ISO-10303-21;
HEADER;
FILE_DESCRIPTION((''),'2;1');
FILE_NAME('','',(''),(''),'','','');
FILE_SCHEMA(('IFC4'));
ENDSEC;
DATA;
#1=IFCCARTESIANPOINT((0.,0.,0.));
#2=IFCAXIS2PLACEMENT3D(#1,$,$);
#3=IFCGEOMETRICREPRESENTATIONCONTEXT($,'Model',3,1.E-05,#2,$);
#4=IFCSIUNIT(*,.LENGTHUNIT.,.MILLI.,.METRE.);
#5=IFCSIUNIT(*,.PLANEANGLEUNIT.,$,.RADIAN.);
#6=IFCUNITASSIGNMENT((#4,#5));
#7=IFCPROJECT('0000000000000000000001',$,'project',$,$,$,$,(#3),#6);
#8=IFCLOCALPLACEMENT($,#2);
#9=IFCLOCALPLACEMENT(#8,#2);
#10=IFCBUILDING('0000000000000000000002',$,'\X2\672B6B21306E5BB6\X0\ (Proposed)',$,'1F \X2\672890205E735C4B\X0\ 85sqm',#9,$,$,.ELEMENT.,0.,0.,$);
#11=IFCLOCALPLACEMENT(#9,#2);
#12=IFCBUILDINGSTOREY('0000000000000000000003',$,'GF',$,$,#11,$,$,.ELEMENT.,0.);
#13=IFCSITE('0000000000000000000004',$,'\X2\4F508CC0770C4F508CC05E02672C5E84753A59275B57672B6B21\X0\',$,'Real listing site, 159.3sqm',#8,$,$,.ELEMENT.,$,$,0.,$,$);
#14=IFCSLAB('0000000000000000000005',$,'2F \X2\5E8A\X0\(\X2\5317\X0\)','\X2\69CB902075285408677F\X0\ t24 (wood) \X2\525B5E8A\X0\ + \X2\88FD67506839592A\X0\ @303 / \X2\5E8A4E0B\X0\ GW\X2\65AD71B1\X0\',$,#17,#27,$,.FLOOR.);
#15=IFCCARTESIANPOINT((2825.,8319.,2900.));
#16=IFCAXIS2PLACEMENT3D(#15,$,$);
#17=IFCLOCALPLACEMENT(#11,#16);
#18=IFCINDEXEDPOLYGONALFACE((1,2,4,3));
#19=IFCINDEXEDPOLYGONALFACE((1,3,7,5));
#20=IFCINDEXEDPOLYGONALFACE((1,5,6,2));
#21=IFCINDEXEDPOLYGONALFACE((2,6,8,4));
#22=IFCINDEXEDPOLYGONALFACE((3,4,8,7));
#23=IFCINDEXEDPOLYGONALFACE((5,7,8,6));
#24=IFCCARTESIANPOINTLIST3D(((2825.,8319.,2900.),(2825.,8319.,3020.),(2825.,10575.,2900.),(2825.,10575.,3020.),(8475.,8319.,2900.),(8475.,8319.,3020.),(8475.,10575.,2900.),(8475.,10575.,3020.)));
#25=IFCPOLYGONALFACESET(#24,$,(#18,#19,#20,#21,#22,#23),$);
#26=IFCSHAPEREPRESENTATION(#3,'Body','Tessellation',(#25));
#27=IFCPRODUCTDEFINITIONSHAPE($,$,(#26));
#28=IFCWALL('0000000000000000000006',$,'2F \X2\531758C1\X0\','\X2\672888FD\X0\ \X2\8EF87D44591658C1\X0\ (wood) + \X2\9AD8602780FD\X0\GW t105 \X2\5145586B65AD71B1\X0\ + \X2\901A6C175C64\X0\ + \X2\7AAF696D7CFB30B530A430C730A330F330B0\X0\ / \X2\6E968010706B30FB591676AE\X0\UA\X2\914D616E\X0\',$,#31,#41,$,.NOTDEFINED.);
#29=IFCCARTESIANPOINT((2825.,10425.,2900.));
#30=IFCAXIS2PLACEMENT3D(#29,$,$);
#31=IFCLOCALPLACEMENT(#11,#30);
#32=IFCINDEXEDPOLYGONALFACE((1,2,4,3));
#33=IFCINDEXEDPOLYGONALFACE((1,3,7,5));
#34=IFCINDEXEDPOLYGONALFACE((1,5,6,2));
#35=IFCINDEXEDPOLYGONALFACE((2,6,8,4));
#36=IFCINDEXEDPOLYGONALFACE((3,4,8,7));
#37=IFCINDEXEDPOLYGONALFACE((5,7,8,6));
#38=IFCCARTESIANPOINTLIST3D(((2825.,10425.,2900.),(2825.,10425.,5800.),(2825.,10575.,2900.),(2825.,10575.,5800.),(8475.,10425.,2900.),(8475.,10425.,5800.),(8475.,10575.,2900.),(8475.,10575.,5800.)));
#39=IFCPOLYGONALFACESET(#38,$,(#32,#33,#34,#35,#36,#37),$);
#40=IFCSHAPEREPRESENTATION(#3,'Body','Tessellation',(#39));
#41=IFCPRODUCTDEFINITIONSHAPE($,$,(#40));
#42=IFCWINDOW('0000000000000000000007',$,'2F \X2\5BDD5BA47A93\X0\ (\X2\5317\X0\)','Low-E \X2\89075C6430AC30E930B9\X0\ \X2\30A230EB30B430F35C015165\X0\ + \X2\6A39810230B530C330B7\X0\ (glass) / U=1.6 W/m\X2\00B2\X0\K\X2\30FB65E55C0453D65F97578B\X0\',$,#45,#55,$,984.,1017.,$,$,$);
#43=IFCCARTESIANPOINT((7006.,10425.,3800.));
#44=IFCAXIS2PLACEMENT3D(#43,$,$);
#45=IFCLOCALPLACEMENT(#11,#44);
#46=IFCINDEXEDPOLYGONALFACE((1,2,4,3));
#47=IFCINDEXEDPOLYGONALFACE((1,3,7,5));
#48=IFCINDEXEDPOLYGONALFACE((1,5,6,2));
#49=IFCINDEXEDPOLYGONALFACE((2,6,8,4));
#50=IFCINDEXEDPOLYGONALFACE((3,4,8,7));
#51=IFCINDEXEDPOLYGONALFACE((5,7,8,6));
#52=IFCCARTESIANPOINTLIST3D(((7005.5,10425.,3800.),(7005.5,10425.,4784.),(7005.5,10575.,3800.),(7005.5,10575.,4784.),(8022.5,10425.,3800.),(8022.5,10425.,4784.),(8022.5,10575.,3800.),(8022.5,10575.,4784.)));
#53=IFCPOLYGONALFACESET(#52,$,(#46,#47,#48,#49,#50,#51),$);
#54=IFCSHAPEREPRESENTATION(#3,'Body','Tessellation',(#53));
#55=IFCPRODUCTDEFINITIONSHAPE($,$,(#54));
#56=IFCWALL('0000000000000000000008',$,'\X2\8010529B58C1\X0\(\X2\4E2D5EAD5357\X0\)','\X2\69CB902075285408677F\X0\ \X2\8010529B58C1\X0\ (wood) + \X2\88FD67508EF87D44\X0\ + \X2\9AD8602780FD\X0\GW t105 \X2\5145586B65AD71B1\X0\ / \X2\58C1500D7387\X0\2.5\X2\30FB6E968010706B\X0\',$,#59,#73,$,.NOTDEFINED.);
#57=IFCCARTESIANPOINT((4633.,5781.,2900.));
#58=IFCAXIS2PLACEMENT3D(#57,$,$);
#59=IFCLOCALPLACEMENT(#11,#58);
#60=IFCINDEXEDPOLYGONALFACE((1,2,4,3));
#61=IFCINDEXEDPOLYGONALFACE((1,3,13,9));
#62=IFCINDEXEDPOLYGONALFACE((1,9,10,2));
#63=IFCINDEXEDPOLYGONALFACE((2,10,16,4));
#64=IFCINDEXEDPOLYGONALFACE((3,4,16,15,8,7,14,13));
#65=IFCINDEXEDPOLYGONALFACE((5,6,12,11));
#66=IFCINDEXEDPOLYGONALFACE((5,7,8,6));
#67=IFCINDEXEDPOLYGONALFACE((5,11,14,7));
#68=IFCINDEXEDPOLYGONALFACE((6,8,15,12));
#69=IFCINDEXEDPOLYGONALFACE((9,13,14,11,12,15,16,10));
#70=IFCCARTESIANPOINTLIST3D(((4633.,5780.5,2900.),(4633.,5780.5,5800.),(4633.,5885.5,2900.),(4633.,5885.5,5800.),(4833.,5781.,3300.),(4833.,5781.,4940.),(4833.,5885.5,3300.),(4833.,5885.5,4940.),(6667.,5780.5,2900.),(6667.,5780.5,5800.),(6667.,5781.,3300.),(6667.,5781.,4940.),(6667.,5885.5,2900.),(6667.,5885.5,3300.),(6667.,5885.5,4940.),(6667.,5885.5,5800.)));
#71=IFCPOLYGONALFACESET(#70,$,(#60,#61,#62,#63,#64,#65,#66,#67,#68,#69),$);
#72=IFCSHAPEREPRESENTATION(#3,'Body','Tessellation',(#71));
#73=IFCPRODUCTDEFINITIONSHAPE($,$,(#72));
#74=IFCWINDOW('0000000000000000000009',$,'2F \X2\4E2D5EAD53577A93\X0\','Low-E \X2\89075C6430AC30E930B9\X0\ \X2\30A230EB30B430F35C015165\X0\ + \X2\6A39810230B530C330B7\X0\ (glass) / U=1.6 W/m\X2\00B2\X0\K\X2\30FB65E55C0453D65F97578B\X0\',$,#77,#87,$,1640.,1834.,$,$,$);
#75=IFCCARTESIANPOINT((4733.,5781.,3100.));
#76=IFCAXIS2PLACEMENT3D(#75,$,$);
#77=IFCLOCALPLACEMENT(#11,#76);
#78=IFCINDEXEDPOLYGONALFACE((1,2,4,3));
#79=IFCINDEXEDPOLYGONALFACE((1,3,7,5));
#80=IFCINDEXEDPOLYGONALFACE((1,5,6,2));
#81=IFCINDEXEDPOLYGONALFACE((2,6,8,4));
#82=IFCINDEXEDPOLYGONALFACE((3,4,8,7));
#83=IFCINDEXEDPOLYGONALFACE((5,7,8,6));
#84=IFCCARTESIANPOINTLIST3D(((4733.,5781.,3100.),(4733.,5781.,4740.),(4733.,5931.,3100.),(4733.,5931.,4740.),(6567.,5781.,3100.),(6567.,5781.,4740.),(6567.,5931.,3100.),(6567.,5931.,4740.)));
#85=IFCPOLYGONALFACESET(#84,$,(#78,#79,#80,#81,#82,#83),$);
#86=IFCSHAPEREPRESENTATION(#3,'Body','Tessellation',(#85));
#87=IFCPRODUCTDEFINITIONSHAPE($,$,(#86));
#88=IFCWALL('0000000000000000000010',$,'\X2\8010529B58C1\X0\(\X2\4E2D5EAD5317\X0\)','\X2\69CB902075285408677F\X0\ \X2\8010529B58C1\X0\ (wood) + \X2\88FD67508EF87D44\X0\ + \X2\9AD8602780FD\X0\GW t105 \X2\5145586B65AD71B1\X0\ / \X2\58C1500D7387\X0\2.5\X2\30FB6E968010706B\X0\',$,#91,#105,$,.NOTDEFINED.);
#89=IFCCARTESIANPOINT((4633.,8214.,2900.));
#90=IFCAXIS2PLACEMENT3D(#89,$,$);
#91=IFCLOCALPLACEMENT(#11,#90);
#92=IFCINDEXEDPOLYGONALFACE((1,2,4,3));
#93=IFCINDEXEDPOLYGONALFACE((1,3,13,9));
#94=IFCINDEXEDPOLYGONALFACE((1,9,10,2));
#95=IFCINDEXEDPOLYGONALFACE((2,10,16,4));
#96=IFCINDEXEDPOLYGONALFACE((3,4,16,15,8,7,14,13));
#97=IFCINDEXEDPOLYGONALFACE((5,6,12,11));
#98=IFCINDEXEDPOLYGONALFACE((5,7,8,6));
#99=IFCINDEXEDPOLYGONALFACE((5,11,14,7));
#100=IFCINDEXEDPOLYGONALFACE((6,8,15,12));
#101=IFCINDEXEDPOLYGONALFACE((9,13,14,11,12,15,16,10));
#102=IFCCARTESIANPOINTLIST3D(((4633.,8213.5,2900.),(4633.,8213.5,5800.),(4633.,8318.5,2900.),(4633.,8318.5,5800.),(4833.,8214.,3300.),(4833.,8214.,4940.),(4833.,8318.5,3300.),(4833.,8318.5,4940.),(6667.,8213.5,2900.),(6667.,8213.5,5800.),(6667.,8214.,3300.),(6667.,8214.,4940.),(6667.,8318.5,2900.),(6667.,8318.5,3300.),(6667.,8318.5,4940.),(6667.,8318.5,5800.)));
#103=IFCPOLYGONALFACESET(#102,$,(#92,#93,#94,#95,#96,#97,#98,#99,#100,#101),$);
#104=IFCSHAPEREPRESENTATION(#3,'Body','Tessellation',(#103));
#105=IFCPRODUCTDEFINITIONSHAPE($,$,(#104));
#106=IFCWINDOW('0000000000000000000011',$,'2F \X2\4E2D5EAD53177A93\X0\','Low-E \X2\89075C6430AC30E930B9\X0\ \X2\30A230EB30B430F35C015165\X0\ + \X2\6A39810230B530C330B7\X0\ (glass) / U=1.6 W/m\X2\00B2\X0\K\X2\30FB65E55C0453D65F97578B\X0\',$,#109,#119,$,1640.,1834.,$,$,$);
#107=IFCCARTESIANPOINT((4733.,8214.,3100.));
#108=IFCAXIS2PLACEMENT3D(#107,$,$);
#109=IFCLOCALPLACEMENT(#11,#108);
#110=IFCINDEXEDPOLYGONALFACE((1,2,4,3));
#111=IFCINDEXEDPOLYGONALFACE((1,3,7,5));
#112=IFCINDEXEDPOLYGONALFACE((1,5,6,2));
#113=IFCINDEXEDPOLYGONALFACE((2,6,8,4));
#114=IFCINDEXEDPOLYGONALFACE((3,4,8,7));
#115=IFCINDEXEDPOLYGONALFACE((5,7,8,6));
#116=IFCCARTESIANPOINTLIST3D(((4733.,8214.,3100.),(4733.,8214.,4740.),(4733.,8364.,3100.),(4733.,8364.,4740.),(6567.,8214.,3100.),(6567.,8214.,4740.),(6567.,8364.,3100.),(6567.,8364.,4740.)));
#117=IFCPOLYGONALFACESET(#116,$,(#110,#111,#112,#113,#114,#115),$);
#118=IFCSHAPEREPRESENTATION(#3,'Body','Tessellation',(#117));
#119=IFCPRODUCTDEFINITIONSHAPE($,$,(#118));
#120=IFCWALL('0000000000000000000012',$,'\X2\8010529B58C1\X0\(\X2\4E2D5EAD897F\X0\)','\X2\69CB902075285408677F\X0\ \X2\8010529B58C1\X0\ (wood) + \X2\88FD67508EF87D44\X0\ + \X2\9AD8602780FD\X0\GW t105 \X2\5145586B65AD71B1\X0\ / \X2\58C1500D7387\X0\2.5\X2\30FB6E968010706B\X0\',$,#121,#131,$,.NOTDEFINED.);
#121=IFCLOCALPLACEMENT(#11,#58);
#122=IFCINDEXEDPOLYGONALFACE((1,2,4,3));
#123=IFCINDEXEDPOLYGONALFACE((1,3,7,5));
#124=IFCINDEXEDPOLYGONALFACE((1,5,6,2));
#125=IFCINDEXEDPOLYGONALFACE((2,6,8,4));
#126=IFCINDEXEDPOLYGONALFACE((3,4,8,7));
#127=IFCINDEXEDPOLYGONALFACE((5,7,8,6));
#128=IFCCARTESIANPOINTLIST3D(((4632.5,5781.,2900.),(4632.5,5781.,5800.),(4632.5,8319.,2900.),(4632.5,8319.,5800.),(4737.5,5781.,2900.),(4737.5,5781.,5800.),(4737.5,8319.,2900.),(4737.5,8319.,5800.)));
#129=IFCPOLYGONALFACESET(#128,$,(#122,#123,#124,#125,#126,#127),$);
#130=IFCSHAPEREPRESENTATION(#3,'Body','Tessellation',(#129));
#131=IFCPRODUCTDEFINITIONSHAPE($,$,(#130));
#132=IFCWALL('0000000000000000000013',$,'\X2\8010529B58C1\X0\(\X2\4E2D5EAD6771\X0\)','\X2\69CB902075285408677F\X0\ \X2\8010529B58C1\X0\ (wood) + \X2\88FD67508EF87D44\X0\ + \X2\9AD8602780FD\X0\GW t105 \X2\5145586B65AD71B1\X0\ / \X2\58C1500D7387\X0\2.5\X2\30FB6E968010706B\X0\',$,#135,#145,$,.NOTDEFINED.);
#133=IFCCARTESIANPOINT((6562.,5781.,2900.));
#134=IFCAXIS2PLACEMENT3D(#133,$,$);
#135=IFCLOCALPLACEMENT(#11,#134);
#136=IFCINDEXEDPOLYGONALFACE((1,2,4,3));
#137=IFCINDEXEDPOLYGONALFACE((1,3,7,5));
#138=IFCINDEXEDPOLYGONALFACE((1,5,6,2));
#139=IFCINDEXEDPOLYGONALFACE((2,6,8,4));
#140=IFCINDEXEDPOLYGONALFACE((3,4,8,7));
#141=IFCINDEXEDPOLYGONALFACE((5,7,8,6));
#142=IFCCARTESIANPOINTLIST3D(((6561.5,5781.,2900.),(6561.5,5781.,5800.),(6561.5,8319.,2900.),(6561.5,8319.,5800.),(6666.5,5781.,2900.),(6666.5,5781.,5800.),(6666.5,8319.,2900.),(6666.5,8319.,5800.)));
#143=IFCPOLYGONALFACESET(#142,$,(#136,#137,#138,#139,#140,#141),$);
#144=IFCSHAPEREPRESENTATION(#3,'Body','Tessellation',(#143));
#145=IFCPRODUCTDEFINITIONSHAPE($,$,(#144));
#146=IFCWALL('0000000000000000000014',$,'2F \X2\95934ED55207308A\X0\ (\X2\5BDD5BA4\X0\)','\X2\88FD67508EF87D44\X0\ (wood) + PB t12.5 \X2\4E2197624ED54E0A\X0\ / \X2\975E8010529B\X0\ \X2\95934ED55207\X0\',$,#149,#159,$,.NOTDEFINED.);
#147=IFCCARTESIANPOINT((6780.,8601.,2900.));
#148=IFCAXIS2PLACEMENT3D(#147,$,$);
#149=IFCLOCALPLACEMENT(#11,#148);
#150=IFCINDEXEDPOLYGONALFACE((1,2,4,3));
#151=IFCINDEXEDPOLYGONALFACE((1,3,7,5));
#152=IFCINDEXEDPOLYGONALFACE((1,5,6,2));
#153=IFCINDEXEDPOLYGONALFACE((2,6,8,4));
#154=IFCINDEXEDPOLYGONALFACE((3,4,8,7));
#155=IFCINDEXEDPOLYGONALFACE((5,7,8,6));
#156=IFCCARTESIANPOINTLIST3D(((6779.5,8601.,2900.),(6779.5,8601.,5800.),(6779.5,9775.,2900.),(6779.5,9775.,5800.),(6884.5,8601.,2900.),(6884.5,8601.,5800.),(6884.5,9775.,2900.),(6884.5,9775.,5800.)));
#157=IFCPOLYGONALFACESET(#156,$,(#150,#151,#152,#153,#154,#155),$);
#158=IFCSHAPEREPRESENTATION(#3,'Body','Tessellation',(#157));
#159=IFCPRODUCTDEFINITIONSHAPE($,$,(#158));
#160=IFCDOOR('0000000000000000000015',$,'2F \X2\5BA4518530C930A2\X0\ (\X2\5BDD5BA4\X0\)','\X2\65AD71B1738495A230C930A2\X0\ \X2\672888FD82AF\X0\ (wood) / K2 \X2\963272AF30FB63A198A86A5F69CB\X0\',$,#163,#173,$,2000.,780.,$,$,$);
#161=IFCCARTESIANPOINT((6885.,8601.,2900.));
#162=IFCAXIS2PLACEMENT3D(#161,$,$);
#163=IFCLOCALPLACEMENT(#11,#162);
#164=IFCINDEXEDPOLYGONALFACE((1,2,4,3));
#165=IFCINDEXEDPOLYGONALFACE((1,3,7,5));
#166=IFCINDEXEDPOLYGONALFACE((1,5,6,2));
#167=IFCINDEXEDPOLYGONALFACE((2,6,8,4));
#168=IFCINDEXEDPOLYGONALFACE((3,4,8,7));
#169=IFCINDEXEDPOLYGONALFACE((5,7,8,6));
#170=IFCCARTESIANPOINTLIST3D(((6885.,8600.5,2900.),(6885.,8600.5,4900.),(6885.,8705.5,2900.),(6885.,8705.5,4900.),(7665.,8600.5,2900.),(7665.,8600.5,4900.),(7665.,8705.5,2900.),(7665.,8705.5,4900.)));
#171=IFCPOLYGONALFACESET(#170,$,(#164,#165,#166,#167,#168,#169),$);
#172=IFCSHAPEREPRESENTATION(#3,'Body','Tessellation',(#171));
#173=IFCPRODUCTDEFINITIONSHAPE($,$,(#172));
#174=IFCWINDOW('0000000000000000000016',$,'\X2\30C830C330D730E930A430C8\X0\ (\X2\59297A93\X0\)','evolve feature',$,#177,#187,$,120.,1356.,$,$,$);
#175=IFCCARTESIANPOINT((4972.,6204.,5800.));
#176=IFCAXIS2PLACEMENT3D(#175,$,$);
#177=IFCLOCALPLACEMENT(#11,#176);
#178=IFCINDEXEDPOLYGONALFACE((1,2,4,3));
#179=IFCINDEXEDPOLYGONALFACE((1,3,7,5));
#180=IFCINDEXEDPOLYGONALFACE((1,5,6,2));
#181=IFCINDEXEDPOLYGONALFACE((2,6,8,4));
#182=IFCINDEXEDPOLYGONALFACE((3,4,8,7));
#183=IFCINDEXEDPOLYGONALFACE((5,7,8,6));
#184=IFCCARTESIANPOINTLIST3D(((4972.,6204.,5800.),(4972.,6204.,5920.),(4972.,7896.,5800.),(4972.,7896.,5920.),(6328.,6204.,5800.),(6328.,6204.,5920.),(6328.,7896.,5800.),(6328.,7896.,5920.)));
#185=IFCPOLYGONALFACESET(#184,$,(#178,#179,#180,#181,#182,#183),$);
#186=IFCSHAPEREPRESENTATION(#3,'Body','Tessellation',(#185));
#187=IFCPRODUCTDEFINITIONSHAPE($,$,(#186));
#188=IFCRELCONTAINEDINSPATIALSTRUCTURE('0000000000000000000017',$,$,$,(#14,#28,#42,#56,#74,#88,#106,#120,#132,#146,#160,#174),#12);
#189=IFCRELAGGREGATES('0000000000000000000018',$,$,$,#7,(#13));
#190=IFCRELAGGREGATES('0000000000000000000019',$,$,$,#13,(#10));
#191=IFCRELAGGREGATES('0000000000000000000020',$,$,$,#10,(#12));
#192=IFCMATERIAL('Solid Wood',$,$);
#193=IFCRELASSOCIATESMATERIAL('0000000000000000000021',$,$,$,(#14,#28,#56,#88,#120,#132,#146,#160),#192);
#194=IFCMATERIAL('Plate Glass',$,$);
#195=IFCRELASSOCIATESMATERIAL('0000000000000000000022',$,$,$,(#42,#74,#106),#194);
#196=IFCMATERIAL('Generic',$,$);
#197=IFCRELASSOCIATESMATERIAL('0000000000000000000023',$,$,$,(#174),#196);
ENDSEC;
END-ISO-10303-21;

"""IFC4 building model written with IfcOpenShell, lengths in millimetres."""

from ifc_helpers import new_model, si_unit, frame, frame_2d, origin, place, context, project, spatial, rectangle, extrude, material, element, fill, save


model = new_model("IFC4")

# Units and contexts
model_context = context("Model", 3, precision=1e-05, world=origin())
ifc_project = project(units=[si_unit("LENGTHUNIT", "METRE", prefix="MILLI"), si_unit("PLANEANGLEUNIT", "RADIAN")], contexts=[model_context])

# Site, building, storey
site_placement = place(None, origin())
site = spatial("IfcSite", under=ifc_project, at=site_placement, Name="佐賀県佐賀市本庄町大字末次", ObjectType="Real listing site, 159.3sqm", CompositionType="ELEMENT", RefElevation=0.0)
building_placement = place(site_placement, origin())
building = spatial("IfcBuilding", under=site, at=building_placement, Name="末次の家 (Proposed)", ObjectType="1F 木造平屋 85sqm", CompositionType="ELEMENT", ElevationOfRefHeight=0.0, ElevationOfTerrain=0.0)
storey_placement = place(building_placement, origin())
storey = spatial("IfcBuildingStorey", under=building, at=storey_placement, Name="GF", CompositionType="ELEMENT", Elevation=0.0)

# Slab
ifc_material_1 = material(Name="Solid Wood")
slab_placement = place(storey_placement, frame((2825.0, 8319.0, 2900.0)))
element("IfcSlab", 1, at=slab_placement, inside=storey, material=ifc_material_1, Name="2F 床(北)", Description="構造用合板 t24 (wood) 剛床 + 製材根太 @303 / 床下 GW断熱", PredefinedType="FLOOR", context=model_context, shape_type="SweptSolid", body=[
    extrude(rectangle(XDim=5650.0, YDim=2256.0, at=frame_2d((2825.0, 1128.0))), frame((2825.0, 8319.0, 2900.0)), (0.0, 0.0, 1.0), 120.0),
])

# Walls, openings, windows
wall_1_placement = place(storey_placement, frame((2825.0, 10425.0, 2900.0)))
wall_1 = element("IfcWall", 2, at=wall_1_placement, inside=storey, material=ifc_material_1, Name="2F 北壁", Description="木製 軸組外壁 (wood) + 高性能GW t105 充填断熱 + 通気層 + 窯業系サイディング / 準耐火・外皮UA配慮", PredefinedType="NOTDEFINED", context=model_context, shape_type="SweptSolid", body=[
    extrude(rectangle(XDim=5650.0, YDim=150.0, at=frame_2d((2825.0, 75.0))), frame((2825.0, 10425.0, 2900.0)), (0.0, 0.0, 1.0), 2900.0),
])
opening_1_placement = place(storey_placement, frame((7006.0, 10425.0, 3800.0)))
opening_1 = element("IfcOpeningElement", 3, at=opening_1_placement, cuts=wall_1, PredefinedType="NOTDEFINED", context=model_context, shape_type="SweptSolid", body=[
    extrude(rectangle(XDim=1017.0, YDim=150.0, at=frame_2d((508.0, 75.0))), frame((7006.0, 10425.0, 3800.0)), (0.0, 0.0, 1.0), 984.0),
])
ifc_material_2 = material(Name="Plate Glass")
window_1_placement = place(storey_placement, frame((7006.0, 10425.0, 3800.0)))
window_1 = element("IfcWindow", 4, at=window_1_placement, inside=storey, material=ifc_material_2, Name="2F 寝室窓 (北)", Description="Low-E 複層ガラス アルゴン封入 + 樹脂サッシ (glass) / U=1.6 W/m²K・日射取得型", OverallHeight=984.0, OverallWidth=1017.0, context=model_context, shape_type="SweptSolid", body=[
    extrude(rectangle(XDim=1017.0, YDim=150.0, at=frame_2d((508.0, 75.0))), frame((7006.0, 10425.0, 3800.0)), (0.0, 0.0, 1.0), 984.0),
])
fill(opening_1, window_1)
wall_2_placement = place(storey_placement, frame((4633.0, 5781.0, 2900.0)))
wall_2 = element("IfcWall", 5, at=wall_2_placement, inside=storey, material=ifc_material_1, Name="耐力壁(中庭南)", Description="構造用合板 耐力壁 (wood) + 製材軸組 + 高性能GW t105 充填断熱 / 壁倍率2.5・準耐火", PredefinedType="NOTDEFINED", context=model_context, shape_type="SweptSolid", body=[
    extrude(rectangle(XDim=2034.0, YDim=105.0, at=frame_2d((1017.0, 52.0))), frame((4633.0, 5781.0, 2900.0)), (0.0, 0.0, 1.0), 2900.0),
])
opening_2_placement = place(storey_placement, frame((4733.0, 5781.0, 3100.0)))
opening_2 = element("IfcOpeningElement", 6, at=opening_2_placement, cuts=wall_2, PredefinedType="NOTDEFINED", context=model_context, shape_type="SweptSolid", body=[
    extrude(rectangle(XDim=1834.0, YDim=150.0, at=frame_2d((917.0, 75.0))), frame((4733.0, 5781.0, 3100.0)), (0.0, 0.0, 1.0), 1640.0),
])
window_2_placement = place(storey_placement, frame((4733.0, 5781.0, 3100.0)))
window_2 = element("IfcWindow", 7, at=window_2_placement, inside=storey, material=ifc_material_2, Name="2F 中庭南窓", Description="Low-E 複層ガラス アルゴン封入 + 樹脂サッシ (glass) / U=1.6 W/m²K・日射取得型", OverallHeight=1640.0, OverallWidth=1834.0, context=model_context, shape_type="SweptSolid", body=[
    extrude(rectangle(XDim=1834.0, YDim=150.0, at=frame_2d((917.0, 75.0))), frame((4733.0, 5781.0, 3100.0)), (0.0, 0.0, 1.0), 1640.0),
])
fill(opening_2, window_2)
wall_3_placement = place(storey_placement, frame((4633.0, 8214.0, 2900.0)))
wall_3 = element("IfcWall", 8, at=wall_3_placement, inside=storey, material=ifc_material_1, Name="耐力壁(中庭北)", Description="構造用合板 耐力壁 (wood) + 製材軸組 + 高性能GW t105 充填断熱 / 壁倍率2.5・準耐火", PredefinedType="NOTDEFINED", context=model_context, shape_type="SweptSolid", body=[
    extrude(rectangle(XDim=2034.0, YDim=105.0, at=frame_2d((1017.0, 52.0))), frame((4633.0, 8214.0, 2900.0)), (0.0, 0.0, 1.0), 2900.0),
])
opening_3_placement = place(storey_placement, frame((4733.0, 8214.0, 3100.0)))
opening_3 = element("IfcOpeningElement", 9, at=opening_3_placement, cuts=wall_3, PredefinedType="NOTDEFINED", context=model_context, shape_type="SweptSolid", body=[
    extrude(rectangle(XDim=1834.0, YDim=150.0, at=frame_2d((917.0, 75.0))), frame((4733.0, 8214.0, 3100.0)), (0.0, 0.0, 1.0), 1640.0),
])
window_3_placement = place(storey_placement, frame((4733.0, 8214.0, 3100.0)))
window_3 = element("IfcWindow", 10, at=window_3_placement, inside=storey, material=ifc_material_2, Name="2F 中庭北窓", Description="Low-E 複層ガラス アルゴン封入 + 樹脂サッシ (glass) / U=1.6 W/m²K・日射取得型", OverallHeight=1640.0, OverallWidth=1834.0, context=model_context, shape_type="SweptSolid", body=[
    extrude(rectangle(XDim=1834.0, YDim=150.0, at=frame_2d((917.0, 75.0))), frame((4733.0, 8214.0, 3100.0)), (0.0, 0.0, 1.0), 1640.0),
])
fill(opening_3, window_3)

# Walls
wall_4_placement = place(storey_placement, frame((4633.0, 5781.0, 2900.0)))
element("IfcWall", 11, at=wall_4_placement, inside=storey, material=ifc_material_1, Name="耐力壁(中庭西)", Description="構造用合板 耐力壁 (wood) + 製材軸組 + 高性能GW t105 充填断熱 / 壁倍率2.5・準耐火", PredefinedType="NOTDEFINED", context=model_context, shape_type="SweptSolid", body=[
    extrude(rectangle(XDim=105.0, YDim=2538.0, at=frame_2d((52.0, 1269.0))), frame((4633.0, 5781.0, 2900.0)), (0.0, 0.0, 1.0), 2900.0),
])
wall_5_placement = place(storey_placement, frame((6562.0, 5781.0, 2900.0)))
element("IfcWall", 12, at=wall_5_placement, inside=storey, material=ifc_material_1, Name="耐力壁(中庭東)", Description="構造用合板 耐力壁 (wood) + 製材軸組 + 高性能GW t105 充填断熱 / 壁倍率2.5・準耐火", PredefinedType="NOTDEFINED", context=model_context, shape_type="SweptSolid", body=[
    extrude(rectangle(XDim=105.0, YDim=2538.0, at=frame_2d((52.0, 1269.0))), frame((6562.0, 5781.0, 2900.0)), (0.0, 0.0, 1.0), 2900.0),
])
wall_6_placement = place(storey_placement, frame((6780.0, 8601.0, 2900.0)))
element("IfcWall", 13, at=wall_6_placement, inside=storey, material=ifc_material_1, Name="2F 間仕切り (寝室)", Description="製材軸組 (wood) + PB t12.5 両面仕上 / 非耐力 間仕切", PredefinedType="NOTDEFINED", context=model_context, shape_type="SweptSolid", body=[
    extrude(rectangle(XDim=105.0, YDim=1174.0, at=frame_2d((52.0, 587.0))), frame((6780.0, 8601.0, 2900.0)), (0.0, 0.0, 1.0), 2900.0),
])

# Door
door_placement = place(storey_placement, frame((6885.0, 8601.0, 2900.0)))
element("IfcDoor", 14, at=door_placement, inside=storey, material=ifc_material_1, Name="2F 室内ドア (寝室)", Description="断熱玄関ドア 木製芯 (wood) / K2 防犯・採風機構", OverallHeight=2000.0, OverallWidth=780.0, context=model_context, shape_type="SweptSolid", body=[
    extrude(rectangle(XDim=780.0, YDim=105.0, at=frame_2d((390.0, 52.0))), frame((6885.0, 8601.0, 2900.0)), (0.0, 0.0, 1.0), 2000.0),
])

# Window
ifc_material_3 = material(Name="Generic")
window_4_placement = place(storey_placement, frame((4972.0, 6204.0, 5800.0)))
element("IfcWindow", 15, at=window_4_placement, inside=storey, material=ifc_material_3, Name="トップライト (天窓)", Description="evolve feature", OverallHeight=120.0, OverallWidth=1356.0, context=model_context, shape_type="SweptSolid", body=[
    extrude(rectangle(XDim=1356.0, YDim=1692.0, at=frame_2d((678.0, 846.0))), frame((4972.0, 6204.0, 5800.0)), (0.0, 0.0, 1.0), 120.0),
])

save(model, "model.ifc")
